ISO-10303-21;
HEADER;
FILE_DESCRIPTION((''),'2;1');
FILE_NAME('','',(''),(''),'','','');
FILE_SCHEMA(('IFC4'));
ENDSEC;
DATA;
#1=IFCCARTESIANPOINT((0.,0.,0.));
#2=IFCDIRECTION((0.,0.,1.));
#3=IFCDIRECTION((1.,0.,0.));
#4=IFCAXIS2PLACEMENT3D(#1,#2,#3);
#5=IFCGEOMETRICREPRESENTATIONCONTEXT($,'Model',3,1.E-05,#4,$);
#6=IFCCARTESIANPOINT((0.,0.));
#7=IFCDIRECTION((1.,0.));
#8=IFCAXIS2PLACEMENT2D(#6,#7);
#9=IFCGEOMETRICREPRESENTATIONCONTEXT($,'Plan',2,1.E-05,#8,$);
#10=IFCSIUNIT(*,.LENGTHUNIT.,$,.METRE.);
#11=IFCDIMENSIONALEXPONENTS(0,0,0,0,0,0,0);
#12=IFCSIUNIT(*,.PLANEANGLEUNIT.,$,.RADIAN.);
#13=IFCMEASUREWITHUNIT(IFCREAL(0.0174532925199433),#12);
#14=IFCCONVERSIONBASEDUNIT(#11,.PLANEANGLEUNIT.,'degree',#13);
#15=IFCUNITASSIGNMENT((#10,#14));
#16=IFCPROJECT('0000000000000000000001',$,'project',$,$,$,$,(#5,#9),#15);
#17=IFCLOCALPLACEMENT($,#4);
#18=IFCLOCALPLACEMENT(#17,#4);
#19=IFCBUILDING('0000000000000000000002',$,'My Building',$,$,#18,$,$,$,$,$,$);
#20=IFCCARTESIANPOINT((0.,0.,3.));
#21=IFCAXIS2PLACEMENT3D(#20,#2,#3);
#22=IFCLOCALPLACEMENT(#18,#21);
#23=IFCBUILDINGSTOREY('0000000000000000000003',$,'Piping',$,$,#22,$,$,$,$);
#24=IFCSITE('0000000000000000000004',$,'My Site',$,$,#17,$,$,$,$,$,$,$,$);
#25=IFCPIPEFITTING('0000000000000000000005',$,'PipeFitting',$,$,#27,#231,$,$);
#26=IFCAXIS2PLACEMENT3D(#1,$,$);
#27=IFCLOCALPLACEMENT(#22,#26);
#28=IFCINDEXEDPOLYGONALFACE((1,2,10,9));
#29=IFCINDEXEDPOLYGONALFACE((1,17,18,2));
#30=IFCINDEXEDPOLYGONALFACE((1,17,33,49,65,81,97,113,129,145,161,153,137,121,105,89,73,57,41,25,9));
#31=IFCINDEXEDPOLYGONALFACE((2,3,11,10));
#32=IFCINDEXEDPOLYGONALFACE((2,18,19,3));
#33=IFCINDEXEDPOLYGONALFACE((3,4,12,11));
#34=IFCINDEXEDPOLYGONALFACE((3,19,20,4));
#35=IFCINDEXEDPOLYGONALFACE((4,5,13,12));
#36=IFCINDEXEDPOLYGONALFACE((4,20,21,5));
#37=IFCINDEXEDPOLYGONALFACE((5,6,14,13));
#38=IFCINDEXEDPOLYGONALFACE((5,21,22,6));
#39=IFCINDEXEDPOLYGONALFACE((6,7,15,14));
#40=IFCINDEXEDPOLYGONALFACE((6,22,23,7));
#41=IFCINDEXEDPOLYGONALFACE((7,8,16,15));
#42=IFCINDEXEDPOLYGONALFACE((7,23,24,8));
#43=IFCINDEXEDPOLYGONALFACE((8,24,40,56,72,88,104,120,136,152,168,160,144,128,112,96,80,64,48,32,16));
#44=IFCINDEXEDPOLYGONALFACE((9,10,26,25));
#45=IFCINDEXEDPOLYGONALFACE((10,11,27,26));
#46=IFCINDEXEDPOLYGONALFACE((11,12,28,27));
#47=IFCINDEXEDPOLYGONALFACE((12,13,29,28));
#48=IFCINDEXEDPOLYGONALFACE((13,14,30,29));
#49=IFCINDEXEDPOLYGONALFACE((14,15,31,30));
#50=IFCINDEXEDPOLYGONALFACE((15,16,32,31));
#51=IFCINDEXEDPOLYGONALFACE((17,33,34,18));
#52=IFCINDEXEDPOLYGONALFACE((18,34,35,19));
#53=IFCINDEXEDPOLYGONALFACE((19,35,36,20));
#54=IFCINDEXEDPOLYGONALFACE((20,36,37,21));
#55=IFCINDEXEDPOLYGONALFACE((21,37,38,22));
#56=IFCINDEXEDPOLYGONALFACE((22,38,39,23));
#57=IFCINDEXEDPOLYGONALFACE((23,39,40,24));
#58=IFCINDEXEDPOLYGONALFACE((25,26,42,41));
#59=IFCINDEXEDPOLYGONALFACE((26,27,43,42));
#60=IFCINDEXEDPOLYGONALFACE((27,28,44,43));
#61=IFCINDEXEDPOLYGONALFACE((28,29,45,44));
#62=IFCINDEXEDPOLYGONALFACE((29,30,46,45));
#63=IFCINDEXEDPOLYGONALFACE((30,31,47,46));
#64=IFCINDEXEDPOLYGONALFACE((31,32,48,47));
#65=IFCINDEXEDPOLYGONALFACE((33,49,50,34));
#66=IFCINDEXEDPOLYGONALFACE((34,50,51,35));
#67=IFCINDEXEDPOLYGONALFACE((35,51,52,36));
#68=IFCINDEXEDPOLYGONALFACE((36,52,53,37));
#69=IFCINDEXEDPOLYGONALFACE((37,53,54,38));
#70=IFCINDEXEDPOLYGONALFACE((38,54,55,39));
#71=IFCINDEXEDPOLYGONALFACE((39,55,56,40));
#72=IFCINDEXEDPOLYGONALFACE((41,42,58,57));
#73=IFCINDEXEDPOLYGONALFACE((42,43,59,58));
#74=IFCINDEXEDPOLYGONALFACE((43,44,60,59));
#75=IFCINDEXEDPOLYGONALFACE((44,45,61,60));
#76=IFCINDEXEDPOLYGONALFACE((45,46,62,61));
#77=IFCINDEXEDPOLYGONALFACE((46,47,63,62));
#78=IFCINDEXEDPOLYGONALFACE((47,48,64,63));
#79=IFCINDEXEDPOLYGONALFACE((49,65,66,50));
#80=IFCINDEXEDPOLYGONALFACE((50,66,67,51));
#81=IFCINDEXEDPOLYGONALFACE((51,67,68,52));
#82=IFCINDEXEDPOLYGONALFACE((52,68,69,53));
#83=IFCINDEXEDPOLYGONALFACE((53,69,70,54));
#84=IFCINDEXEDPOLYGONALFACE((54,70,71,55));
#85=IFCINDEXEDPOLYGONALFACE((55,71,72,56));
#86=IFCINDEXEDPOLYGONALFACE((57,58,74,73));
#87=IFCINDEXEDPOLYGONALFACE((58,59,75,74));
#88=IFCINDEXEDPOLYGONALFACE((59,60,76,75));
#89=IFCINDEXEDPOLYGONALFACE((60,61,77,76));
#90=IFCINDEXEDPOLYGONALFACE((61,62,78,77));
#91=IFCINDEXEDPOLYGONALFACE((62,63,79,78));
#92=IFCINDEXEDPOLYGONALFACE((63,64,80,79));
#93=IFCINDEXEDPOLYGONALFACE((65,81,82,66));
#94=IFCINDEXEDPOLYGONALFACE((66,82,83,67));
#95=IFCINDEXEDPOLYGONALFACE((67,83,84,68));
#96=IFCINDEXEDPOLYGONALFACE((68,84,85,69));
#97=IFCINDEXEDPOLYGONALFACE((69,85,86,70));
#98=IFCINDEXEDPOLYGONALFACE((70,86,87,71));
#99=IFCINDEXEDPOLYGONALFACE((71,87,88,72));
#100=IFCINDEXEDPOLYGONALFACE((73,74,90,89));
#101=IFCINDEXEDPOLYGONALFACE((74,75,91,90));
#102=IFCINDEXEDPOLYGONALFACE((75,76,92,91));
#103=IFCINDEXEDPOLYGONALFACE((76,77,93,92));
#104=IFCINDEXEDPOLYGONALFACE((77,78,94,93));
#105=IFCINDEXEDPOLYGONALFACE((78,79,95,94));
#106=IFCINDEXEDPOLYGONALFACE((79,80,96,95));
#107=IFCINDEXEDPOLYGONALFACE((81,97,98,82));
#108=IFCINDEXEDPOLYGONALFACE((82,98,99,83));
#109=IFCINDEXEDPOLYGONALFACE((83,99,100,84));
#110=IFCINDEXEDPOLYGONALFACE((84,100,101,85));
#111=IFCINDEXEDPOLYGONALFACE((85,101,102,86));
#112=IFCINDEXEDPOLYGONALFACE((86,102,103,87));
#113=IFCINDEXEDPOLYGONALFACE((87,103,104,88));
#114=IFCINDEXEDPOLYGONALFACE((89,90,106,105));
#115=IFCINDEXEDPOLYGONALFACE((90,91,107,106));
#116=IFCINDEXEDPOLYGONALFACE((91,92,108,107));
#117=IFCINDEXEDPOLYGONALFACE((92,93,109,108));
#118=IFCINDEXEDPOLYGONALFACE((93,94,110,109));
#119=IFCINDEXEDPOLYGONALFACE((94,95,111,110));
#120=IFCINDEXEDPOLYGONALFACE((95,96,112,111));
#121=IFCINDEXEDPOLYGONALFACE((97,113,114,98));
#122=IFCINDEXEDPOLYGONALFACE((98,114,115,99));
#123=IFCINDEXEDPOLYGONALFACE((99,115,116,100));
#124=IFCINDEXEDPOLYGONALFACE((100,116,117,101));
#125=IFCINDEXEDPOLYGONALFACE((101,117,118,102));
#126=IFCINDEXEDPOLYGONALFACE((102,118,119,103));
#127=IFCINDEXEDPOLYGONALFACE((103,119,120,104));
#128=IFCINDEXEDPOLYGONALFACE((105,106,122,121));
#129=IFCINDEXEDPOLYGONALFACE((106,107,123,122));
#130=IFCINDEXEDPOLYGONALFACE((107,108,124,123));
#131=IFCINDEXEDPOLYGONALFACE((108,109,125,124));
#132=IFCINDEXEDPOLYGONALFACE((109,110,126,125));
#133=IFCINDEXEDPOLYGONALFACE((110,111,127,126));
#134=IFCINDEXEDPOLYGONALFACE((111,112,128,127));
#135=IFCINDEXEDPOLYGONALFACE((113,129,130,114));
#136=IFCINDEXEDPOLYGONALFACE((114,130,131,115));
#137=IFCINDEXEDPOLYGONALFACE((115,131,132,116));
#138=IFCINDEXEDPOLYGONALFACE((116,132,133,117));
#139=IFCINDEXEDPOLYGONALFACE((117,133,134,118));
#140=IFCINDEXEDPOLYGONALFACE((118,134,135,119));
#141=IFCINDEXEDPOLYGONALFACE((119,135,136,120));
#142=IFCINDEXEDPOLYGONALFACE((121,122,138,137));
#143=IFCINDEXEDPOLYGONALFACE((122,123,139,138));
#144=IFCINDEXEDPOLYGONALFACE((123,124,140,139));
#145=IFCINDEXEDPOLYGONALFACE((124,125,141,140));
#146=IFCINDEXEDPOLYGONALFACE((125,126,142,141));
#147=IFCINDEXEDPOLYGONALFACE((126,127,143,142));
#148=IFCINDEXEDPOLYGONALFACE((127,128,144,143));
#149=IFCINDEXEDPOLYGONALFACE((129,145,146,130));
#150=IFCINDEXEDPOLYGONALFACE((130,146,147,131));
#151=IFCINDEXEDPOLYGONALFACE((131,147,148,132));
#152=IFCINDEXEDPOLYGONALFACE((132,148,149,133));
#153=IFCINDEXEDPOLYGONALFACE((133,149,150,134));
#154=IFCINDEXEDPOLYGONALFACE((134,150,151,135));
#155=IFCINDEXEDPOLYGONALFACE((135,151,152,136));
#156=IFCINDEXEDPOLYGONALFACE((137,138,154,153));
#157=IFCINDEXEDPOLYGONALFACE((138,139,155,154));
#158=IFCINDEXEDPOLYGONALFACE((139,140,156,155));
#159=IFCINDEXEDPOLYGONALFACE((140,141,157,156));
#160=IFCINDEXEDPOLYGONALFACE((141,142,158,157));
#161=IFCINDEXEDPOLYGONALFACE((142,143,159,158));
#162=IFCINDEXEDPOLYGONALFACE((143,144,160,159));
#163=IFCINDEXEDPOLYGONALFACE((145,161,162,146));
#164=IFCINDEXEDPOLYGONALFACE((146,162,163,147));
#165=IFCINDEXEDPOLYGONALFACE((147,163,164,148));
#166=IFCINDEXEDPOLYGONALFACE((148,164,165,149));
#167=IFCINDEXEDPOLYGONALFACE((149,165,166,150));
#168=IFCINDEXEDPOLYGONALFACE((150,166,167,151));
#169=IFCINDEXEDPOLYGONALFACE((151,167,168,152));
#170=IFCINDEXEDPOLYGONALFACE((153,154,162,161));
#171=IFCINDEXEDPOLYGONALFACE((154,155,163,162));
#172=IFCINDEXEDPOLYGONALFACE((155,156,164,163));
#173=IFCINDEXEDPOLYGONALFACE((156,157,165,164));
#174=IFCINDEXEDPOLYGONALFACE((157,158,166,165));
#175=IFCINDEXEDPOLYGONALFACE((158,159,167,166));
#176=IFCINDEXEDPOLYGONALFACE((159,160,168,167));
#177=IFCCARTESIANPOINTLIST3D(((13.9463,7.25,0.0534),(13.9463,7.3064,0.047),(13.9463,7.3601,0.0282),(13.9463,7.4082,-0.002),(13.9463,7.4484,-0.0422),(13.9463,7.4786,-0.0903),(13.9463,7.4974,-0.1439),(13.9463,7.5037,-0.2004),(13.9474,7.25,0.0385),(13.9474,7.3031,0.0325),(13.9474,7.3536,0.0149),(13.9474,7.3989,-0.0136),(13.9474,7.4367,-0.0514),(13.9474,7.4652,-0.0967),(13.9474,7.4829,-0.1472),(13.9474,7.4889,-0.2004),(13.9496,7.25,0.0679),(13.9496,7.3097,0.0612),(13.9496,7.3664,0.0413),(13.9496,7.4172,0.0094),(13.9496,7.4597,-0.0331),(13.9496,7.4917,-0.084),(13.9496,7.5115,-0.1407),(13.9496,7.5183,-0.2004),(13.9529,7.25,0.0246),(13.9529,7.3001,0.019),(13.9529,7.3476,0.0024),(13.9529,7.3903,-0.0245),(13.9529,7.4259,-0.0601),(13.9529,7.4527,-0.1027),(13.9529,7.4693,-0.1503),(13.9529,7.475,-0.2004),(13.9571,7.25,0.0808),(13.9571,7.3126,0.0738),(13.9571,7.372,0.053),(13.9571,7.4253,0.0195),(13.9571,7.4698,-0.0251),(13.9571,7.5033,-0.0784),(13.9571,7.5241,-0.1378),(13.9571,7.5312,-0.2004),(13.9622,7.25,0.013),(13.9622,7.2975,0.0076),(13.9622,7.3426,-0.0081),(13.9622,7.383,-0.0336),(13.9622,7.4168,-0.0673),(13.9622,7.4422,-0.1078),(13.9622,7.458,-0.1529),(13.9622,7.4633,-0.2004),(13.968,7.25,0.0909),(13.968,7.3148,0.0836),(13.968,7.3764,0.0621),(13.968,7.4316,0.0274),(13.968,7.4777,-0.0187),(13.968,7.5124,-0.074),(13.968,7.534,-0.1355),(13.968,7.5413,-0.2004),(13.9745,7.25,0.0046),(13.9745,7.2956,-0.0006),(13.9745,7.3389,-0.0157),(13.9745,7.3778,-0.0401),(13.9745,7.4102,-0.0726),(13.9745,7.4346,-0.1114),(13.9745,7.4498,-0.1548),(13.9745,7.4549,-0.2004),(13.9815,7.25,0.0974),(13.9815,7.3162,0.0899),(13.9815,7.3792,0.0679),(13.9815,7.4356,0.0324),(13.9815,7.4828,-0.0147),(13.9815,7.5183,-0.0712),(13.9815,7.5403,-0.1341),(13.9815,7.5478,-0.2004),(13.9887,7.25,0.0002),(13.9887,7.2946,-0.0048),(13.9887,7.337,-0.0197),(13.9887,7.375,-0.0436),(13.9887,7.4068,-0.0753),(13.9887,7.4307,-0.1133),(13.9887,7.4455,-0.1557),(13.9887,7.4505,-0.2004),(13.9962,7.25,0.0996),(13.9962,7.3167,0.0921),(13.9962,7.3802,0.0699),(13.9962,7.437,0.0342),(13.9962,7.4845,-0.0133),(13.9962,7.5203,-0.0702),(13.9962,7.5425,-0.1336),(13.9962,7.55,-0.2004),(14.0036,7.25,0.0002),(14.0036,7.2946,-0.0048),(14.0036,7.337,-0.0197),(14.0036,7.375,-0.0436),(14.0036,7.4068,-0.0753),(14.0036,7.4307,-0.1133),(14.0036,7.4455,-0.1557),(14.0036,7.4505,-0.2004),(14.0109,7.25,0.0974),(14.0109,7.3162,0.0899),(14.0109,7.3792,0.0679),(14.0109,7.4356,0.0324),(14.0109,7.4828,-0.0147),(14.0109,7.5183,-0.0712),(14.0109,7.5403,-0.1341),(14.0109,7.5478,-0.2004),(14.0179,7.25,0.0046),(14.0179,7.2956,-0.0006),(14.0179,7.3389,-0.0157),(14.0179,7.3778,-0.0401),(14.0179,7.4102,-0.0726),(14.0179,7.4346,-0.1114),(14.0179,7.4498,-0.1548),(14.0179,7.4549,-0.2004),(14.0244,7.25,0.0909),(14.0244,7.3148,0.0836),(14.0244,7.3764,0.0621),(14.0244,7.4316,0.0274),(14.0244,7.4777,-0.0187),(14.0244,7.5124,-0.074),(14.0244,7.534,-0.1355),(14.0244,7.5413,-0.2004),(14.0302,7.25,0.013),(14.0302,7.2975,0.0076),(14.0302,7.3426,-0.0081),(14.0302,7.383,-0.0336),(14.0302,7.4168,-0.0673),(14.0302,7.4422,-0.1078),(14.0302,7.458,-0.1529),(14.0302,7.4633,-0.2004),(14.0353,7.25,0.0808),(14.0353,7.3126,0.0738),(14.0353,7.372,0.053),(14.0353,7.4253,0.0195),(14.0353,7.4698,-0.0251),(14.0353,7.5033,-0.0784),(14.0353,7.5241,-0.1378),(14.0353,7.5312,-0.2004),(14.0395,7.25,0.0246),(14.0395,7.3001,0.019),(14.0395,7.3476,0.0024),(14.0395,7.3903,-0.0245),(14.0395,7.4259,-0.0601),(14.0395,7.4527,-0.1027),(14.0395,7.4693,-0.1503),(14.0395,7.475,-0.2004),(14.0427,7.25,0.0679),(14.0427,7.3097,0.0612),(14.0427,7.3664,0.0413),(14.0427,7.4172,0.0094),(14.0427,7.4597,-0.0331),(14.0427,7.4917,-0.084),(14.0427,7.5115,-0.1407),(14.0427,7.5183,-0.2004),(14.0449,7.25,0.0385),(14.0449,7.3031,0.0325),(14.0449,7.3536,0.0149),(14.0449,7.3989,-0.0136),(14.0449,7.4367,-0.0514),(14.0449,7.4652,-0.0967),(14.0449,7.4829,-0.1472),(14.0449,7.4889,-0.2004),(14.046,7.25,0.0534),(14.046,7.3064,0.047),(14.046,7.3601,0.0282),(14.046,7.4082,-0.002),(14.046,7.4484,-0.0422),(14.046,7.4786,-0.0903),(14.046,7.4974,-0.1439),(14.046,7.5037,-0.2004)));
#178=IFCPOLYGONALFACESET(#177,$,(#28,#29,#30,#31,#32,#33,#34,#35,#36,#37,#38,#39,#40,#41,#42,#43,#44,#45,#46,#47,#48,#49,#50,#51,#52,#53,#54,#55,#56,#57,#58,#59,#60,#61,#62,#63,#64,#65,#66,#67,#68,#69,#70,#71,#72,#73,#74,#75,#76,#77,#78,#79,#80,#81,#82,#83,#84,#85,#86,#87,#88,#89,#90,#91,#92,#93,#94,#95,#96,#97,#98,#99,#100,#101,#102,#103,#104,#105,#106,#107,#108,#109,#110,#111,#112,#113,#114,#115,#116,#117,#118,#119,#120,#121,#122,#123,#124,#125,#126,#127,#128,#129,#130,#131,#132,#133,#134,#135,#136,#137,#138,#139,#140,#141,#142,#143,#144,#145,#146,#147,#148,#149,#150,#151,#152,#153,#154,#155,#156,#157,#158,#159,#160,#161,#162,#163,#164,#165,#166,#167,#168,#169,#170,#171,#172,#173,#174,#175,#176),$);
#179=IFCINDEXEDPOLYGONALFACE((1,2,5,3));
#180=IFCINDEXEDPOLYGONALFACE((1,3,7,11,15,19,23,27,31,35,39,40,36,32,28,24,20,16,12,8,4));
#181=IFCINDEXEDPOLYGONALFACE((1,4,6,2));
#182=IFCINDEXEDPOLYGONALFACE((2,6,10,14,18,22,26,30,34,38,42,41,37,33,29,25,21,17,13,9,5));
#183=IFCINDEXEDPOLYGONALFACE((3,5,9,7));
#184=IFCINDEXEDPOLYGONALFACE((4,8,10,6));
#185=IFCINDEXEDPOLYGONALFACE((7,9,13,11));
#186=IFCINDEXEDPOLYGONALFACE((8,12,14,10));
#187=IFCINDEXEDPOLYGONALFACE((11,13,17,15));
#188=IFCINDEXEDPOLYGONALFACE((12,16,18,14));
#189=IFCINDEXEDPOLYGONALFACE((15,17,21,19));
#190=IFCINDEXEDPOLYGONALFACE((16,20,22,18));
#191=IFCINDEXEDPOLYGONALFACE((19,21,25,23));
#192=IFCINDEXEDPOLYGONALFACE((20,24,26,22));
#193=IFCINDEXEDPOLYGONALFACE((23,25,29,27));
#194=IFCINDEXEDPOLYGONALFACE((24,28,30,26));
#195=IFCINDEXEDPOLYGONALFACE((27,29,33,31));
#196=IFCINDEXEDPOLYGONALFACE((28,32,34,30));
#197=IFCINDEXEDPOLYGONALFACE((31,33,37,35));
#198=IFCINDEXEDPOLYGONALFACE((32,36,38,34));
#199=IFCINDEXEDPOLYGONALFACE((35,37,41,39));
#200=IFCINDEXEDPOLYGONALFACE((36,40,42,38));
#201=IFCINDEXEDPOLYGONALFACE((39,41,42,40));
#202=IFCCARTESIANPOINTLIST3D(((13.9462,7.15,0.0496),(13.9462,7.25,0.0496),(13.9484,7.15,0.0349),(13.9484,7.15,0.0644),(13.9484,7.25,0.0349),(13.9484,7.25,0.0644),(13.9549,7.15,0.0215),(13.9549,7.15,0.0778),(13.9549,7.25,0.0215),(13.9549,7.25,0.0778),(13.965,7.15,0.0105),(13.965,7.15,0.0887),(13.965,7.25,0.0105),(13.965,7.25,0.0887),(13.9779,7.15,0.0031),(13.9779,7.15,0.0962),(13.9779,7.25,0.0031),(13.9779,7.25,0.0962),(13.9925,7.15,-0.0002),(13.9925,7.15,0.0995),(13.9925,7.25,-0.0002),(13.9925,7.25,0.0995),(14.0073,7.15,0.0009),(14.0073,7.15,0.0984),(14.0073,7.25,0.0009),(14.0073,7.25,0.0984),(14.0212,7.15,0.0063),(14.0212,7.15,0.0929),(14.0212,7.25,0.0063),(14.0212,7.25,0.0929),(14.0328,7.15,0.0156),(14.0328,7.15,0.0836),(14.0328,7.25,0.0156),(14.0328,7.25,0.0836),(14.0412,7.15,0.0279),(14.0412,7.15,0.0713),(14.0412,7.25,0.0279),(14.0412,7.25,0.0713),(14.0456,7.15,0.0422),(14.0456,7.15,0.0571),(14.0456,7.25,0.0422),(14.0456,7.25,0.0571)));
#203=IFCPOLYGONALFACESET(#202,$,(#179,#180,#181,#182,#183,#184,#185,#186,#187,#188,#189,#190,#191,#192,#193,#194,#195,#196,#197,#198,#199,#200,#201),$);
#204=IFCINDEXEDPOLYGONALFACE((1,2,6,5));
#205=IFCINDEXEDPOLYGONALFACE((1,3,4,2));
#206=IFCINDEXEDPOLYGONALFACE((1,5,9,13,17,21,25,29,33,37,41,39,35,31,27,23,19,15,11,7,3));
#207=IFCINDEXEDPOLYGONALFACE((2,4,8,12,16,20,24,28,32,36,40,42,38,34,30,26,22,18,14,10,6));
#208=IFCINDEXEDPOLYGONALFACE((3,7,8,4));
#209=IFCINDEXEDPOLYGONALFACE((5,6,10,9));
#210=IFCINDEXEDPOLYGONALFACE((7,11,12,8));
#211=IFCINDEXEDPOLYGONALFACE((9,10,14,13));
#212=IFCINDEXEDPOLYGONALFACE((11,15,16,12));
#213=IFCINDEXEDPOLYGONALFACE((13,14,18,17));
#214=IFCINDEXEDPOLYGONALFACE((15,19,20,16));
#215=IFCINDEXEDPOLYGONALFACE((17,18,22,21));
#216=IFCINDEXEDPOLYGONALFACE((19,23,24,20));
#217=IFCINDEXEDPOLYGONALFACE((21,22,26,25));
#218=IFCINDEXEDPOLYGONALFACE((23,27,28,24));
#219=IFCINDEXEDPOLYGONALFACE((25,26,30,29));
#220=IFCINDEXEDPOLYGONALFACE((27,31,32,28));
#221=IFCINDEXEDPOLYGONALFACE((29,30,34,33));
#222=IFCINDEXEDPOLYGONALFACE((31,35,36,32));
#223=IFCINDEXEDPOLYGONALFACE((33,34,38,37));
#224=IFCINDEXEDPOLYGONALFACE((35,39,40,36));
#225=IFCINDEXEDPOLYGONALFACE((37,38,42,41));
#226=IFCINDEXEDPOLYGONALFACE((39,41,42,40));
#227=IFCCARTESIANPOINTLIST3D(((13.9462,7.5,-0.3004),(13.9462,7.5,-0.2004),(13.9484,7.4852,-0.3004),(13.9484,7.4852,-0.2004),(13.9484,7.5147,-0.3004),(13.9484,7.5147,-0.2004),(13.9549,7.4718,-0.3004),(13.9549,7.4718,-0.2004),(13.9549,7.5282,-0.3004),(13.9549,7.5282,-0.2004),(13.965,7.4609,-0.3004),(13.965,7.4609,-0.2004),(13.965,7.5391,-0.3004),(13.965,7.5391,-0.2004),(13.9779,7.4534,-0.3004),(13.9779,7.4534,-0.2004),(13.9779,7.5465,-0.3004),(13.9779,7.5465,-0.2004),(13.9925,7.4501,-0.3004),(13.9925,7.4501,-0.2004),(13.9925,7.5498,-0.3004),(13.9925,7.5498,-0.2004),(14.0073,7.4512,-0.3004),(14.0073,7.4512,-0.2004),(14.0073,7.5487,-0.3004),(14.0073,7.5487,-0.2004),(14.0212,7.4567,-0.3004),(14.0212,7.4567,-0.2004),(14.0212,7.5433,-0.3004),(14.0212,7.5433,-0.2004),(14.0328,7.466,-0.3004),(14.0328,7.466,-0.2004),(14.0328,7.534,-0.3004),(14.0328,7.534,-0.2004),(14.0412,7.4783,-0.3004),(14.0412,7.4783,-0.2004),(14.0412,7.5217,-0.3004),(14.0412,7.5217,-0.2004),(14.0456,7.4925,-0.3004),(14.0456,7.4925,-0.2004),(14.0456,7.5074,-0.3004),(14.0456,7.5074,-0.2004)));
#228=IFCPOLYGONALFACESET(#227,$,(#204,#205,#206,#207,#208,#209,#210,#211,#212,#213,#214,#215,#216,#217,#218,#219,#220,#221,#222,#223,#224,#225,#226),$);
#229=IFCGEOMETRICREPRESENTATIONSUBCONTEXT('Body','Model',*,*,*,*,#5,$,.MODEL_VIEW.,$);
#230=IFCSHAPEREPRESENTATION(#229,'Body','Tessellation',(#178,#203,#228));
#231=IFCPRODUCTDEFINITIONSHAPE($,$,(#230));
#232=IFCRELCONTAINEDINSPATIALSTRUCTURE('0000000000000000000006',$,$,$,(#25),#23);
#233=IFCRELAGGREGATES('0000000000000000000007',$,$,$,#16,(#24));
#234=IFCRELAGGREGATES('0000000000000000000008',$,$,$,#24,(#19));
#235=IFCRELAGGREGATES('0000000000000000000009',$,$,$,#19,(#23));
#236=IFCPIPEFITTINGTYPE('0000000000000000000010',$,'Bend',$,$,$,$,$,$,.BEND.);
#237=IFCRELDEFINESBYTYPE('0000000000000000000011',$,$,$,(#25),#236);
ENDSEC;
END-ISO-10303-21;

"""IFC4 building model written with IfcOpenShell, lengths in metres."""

from ifc_helpers import new_model, entity, si_unit, converted_unit, frame, origin_with_axes, origin_2d_with_axis, place, context, subcontext, project, spatial, circle, extrude, source, transform, mapped, type_object, type_shapes, element, save


model = new_model("IFC4")

# Units and contexts
model_context = context("Model", 3, precision=1e-05, world=origin_with_axes())
plan_context = context("Plan", 2, precision=1e-05, world=origin_2d_with_axis())
body_context = subcontext(model_context, "Body", "Model", "MODEL_VIEW")
ifc_project = project(units=[si_unit("LENGTHUNIT", "METRE"), converted_unit("PLANEANGLEUNIT", "degree", entity("IfcReal", 0.0174532925199433), si_unit("PLANEANGLEUNIT", "RADIAN"), dimensions=[0, 0, 0, 0, 0, 0, 0])], contexts=[model_context, plan_context])

# Site, building, storey
site_placement = place(None, origin_with_axes())
site = spatial("IfcSite", under=ifc_project, at=site_placement, Name="My Site")
building_placement = place(site_placement, origin_with_axes())
building = spatial("IfcBuilding", under=site, at=building_placement, Name="My Building")
storey_placement = place(building_placement, frame((0.0, 0.0, 3.0), z_axis=(0.0, 0.0, 1.0), x_axis=(1.0, 0.0, 0.0)))
storey = spatial("IfcBuildingStorey", under=building, at=storey_placement, Name="Piping")

# Pipe fitting
pipe_fitting_type_1 = type_object("IfcPipeFittingType", Name="Bend", PredefinedType="BEND")
shared_shape = source(origin_with_axes(), body_context, "Body", "SolidModel", [
    entity("IfcSweptDiskSolid", entity("IfcIndexedPolyCurve", entity("IfcCartesianPointList3D", [[0.0, 0.0, 0.1], [0.0, -0.0732, 0.2768], [0.0, -0.25, 0.35]]), [entity("IfcArcIndex", [1, 2, 3])]), 0.05),
    extrude(circle(Radius=0.05), origin_with_axes(), (0.0, 0.0, 1.0), 0.1),
    extrude(circle(Radius=0.05), frame((0.0, -0.25, 0.35), z_axis=(0.0, -1.0, 0.0), x_axis=(1.0, 0.0, 0.0)), (0.0, 0.0, 1.0), 0.1),
])
type_shapes(pipe_fitting_type_1, [shared_shape])
for number, where, z_axis, x_axis, name in (
    (1, (13.9962, 7.15, 0.0496), (0.0, 1.0, 0.0), (-1.0, 0.0, 0.0), "PipeFitting"),
):
    element("IfcPipeFitting", number, at=place(storey_placement, frame(where, z_axis=z_axis, x_axis=x_axis)), inside=storey, type_object=pipe_fitting_type_1, Name=name, context=body_context, shape_type="MappedRepresentation", body=[
        mapped(shared_shape, transform((0.0, 0.0, 0.0), x_axis=(1.0, 0.0, 0.0), y_axis=(0.0, 1.0, 0.0), z_axis=(0.0, 0.0, 1.0), scale=1.0)),
    ])

save(model, "model.ifc")
